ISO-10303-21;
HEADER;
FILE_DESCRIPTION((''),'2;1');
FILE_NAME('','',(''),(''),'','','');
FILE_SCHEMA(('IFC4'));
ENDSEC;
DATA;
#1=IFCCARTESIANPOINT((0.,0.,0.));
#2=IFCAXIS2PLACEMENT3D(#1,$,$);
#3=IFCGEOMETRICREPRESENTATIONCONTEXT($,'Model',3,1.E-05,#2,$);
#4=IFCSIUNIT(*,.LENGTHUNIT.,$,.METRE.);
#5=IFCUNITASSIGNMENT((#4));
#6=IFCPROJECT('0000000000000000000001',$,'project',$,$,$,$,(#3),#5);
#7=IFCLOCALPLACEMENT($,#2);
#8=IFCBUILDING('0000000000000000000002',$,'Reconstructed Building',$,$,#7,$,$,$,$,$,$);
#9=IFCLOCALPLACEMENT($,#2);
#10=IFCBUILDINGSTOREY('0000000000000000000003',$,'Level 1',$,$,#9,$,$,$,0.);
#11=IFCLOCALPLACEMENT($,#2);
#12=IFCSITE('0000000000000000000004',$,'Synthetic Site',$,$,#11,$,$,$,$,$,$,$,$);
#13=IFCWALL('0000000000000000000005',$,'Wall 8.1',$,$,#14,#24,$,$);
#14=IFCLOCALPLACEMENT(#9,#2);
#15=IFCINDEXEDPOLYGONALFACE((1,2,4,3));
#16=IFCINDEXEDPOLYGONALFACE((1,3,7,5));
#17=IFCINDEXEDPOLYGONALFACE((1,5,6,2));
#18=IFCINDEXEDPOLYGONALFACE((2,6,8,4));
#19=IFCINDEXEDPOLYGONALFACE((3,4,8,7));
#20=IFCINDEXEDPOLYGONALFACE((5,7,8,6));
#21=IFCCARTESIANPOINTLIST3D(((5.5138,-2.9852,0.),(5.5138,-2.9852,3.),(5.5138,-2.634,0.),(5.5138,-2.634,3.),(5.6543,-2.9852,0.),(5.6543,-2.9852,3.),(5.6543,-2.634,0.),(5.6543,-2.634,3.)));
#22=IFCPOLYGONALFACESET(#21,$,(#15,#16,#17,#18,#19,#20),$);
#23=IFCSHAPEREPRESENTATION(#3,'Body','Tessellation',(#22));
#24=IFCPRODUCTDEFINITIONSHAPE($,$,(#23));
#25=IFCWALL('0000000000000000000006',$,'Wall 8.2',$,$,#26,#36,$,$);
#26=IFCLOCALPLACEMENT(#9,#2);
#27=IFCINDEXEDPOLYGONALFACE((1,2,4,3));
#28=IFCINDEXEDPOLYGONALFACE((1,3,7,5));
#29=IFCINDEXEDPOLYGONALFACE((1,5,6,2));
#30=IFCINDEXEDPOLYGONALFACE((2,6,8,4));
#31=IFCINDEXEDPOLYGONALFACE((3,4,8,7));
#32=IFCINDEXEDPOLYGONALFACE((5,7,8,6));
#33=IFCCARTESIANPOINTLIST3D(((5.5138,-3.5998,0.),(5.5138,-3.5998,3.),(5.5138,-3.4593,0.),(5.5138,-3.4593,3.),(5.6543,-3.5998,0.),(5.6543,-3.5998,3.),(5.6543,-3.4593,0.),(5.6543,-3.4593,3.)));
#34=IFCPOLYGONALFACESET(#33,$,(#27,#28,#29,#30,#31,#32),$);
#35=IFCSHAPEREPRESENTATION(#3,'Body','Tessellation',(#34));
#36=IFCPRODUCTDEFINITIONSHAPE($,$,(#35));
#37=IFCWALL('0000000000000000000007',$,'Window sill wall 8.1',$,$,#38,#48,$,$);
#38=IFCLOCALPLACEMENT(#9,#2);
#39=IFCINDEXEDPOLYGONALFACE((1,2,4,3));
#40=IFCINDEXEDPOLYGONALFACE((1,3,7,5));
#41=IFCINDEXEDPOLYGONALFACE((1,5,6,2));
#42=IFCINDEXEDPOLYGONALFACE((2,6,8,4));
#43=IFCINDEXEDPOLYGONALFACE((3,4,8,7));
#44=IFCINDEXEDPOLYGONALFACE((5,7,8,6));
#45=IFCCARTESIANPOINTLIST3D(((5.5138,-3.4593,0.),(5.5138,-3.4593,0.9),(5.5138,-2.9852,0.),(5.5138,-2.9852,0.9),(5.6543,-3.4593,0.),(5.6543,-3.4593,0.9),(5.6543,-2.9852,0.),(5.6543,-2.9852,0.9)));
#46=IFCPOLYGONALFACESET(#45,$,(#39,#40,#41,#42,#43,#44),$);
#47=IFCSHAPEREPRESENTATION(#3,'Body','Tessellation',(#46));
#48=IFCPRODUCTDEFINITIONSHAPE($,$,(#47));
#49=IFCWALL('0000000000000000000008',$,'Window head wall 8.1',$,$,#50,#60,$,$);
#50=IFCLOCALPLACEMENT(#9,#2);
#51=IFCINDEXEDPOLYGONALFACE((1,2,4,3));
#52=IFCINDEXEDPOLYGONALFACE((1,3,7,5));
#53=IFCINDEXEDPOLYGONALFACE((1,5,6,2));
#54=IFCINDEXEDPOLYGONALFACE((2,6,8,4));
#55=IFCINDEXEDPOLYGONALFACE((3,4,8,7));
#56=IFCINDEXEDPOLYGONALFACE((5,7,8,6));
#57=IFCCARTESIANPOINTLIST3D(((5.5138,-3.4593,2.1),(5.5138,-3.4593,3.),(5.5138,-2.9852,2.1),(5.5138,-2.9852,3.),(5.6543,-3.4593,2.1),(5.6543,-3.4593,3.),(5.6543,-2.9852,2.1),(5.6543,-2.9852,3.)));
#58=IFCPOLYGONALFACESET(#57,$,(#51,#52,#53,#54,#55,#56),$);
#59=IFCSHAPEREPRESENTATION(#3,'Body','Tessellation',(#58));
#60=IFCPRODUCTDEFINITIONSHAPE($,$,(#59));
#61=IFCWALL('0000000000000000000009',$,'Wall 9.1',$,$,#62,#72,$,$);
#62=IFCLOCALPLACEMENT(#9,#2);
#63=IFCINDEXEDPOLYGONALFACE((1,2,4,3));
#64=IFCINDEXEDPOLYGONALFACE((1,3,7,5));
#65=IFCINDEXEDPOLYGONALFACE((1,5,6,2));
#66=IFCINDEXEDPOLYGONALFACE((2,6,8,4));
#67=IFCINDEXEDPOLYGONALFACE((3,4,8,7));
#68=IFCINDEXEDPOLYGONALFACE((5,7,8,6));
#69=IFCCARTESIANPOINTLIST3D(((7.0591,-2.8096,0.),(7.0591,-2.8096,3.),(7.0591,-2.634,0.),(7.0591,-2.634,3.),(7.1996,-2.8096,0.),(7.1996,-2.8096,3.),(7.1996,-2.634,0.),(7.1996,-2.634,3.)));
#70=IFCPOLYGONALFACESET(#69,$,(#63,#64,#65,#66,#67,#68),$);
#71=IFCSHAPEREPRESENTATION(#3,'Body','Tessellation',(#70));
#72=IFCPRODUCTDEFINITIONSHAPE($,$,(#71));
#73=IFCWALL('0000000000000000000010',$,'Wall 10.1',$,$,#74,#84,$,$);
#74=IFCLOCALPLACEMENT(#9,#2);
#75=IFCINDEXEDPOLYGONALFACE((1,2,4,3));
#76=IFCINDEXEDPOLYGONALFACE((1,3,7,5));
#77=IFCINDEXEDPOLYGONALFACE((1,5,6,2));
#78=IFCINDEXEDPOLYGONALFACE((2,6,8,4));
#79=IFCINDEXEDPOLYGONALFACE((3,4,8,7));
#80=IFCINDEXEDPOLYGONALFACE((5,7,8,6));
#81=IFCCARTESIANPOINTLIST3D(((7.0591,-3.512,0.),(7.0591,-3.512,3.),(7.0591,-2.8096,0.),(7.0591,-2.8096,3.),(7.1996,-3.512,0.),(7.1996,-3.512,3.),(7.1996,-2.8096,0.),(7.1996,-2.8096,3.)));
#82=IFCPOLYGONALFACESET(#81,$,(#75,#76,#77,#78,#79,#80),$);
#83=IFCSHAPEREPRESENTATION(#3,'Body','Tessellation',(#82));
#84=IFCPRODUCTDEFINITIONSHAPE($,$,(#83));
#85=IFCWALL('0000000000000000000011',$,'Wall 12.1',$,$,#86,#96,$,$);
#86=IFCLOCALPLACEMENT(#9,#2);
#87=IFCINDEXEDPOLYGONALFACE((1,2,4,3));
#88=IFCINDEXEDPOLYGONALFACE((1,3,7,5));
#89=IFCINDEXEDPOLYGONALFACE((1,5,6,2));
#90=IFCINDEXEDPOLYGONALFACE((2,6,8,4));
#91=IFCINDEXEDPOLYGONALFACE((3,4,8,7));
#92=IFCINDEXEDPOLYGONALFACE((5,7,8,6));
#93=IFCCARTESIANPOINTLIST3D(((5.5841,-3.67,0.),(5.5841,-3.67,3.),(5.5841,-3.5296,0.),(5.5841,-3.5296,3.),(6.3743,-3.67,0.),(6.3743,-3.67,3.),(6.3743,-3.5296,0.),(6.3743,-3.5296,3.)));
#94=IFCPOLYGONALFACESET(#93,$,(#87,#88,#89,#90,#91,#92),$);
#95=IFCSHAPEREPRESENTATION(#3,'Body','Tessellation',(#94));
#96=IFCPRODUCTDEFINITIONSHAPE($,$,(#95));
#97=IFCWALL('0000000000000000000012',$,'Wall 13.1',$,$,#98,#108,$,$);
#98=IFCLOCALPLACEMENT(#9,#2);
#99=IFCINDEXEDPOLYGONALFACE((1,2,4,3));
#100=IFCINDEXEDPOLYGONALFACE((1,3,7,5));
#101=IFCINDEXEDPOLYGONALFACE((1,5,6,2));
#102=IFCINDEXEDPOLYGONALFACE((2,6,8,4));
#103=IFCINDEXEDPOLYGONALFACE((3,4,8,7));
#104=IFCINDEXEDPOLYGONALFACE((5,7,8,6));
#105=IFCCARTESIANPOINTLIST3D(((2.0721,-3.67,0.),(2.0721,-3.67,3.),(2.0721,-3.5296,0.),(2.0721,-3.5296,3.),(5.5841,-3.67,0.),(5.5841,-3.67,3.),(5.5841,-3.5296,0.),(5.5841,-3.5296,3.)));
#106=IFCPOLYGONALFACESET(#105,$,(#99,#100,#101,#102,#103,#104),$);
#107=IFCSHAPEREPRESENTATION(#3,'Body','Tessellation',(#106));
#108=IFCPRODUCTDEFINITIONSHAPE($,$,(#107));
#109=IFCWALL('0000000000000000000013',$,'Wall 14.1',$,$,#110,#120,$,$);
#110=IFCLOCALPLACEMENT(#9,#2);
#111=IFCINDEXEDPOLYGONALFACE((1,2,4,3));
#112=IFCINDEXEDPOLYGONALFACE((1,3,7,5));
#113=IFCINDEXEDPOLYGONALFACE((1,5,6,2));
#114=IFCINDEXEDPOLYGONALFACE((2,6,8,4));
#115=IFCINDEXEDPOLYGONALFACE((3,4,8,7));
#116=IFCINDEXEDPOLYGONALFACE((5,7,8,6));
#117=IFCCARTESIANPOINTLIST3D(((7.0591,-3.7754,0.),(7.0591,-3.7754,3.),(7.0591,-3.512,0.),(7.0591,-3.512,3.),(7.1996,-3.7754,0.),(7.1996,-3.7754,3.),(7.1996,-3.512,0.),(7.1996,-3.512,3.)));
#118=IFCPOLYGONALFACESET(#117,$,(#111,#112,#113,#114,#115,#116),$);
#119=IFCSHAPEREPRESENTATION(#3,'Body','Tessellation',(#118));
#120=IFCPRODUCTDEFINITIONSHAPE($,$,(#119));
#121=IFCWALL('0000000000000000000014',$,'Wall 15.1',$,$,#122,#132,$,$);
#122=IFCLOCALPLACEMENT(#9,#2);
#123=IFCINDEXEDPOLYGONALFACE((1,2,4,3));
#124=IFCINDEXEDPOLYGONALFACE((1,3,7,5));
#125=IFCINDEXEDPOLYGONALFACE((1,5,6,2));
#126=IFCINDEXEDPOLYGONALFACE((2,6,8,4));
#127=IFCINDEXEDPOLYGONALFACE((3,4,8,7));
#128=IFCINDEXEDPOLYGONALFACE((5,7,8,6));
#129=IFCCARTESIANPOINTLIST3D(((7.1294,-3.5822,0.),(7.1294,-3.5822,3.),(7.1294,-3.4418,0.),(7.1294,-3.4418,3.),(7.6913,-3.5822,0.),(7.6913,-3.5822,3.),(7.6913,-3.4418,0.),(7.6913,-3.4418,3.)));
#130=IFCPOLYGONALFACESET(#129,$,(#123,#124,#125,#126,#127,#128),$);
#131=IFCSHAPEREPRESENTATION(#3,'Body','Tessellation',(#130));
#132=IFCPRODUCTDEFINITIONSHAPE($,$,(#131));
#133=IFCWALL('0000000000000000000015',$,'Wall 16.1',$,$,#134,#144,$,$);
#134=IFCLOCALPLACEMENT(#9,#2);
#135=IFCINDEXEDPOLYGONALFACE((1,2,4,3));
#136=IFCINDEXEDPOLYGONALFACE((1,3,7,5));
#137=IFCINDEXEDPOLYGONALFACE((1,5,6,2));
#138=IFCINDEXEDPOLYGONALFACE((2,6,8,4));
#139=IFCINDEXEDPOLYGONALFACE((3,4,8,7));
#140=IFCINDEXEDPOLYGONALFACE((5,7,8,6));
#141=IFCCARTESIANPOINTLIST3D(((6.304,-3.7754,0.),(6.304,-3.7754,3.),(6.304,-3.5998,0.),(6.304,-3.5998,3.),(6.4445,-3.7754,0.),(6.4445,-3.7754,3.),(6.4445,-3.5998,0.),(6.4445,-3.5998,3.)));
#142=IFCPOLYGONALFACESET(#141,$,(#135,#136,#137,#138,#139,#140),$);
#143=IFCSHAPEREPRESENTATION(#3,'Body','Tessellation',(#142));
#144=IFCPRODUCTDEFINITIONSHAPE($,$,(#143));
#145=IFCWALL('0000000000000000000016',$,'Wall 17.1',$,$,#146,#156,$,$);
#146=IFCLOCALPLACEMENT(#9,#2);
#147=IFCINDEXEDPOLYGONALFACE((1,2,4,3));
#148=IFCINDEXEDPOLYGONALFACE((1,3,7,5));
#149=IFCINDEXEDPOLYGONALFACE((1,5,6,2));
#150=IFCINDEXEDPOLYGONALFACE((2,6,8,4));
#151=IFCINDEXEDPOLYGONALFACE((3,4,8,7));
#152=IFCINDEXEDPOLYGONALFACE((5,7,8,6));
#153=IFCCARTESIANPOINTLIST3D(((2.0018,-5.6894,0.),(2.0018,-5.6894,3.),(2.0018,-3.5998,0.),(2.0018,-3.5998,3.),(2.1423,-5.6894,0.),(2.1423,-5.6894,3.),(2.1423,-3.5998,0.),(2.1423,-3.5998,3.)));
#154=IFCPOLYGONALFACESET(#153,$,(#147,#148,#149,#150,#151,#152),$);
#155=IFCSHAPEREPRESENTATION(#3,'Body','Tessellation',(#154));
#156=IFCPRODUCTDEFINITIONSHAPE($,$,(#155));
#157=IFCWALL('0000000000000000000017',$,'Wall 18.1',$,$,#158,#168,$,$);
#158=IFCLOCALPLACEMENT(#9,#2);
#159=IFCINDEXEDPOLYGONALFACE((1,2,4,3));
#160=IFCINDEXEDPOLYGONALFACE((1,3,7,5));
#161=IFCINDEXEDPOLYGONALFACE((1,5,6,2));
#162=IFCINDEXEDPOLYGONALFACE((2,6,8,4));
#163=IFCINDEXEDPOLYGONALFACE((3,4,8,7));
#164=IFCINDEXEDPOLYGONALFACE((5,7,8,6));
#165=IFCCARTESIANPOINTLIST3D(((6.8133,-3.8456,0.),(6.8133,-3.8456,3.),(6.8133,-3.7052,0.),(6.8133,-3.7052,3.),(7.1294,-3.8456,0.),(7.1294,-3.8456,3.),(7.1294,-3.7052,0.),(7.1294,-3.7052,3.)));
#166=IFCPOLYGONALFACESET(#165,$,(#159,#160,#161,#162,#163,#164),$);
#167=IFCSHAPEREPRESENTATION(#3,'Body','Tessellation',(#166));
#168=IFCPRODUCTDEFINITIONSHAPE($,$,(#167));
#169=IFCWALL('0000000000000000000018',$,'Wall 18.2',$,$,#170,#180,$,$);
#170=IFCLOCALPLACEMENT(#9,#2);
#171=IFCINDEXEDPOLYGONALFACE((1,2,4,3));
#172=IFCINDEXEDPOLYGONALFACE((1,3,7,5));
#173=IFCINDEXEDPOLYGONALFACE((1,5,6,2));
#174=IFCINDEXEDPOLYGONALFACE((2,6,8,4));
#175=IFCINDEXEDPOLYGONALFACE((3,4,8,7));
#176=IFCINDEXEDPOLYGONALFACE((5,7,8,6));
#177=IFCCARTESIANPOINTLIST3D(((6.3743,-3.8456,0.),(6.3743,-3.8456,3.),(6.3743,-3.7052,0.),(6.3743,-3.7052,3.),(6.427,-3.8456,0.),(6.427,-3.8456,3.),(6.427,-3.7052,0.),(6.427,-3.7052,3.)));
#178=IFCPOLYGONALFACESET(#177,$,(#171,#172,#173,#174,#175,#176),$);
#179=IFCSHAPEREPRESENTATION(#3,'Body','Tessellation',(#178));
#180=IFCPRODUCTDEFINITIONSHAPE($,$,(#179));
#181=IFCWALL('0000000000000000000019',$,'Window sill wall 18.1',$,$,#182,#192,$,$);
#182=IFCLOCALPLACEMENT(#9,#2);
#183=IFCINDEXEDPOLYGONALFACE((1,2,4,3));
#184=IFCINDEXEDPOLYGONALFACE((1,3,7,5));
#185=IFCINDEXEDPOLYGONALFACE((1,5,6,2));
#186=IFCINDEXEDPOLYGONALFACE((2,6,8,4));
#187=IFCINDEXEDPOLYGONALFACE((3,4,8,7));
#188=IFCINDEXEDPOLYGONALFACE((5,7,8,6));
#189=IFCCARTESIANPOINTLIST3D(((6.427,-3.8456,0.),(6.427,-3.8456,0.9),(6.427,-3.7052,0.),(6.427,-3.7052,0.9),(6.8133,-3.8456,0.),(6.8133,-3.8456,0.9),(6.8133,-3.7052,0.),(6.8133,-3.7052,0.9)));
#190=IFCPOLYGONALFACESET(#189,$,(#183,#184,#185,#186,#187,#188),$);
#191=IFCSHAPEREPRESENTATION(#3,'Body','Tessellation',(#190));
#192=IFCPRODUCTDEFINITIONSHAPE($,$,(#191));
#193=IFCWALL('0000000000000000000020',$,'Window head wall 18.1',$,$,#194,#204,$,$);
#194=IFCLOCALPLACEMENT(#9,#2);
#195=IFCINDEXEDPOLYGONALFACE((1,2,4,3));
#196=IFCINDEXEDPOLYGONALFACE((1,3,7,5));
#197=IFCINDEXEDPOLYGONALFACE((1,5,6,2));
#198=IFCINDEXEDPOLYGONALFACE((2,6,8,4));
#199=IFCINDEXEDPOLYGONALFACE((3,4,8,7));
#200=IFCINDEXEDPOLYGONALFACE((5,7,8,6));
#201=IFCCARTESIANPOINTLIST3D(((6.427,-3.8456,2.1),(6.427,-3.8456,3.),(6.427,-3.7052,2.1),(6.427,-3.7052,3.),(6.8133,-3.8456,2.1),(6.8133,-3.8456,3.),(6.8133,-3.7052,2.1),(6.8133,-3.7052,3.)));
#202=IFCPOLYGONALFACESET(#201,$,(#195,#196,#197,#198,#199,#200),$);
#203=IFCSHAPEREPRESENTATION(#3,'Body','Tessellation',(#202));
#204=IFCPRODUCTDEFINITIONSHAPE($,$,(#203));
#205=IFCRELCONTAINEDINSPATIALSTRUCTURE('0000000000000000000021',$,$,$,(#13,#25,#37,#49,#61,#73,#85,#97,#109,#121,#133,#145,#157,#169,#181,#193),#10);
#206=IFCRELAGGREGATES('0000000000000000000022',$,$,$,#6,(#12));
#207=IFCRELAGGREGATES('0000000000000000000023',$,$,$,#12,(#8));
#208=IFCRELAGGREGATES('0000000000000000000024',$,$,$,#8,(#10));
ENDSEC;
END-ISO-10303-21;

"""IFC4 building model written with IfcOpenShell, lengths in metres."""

from ifc_helpers import new_model, si_unit, frame, origin, place, context, project, spatial, polyline, outline, extrude, element, save


model = new_model("IFC4")

# Units and contexts
model_context = context("Model", 3, precision=1e-05, world=origin())
ifc_project = project(units=[si_unit("LENGTHUNIT", "METRE")], contexts=[model_context])

# Site, building, storey
site_placement = place(None, origin())
site = spatial("IfcSite", under=ifc_project, at=site_placement, Name="Synthetic Site")
building_placement = place(None, origin())
building = spatial("IfcBuilding", under=site, at=building_placement, Name="Reconstructed Building")
storey_placement = place(None, origin())
storey = spatial("IfcBuildingStorey", under=building, at=storey_placement, Name="Level 1", Elevation=0.0)

# Walls
wall_1_placement = place(None, origin())
element("IfcWall", 1, at=wall_1_placement, inside=storey, Name="Wall 8.1", context=model_context, shape_type="SweptSolid", body=[
    extrude(outline(polyline([(5.5138, -2.634), (5.5138, -2.9852), (5.6543, -2.9852), (5.6543, -2.634), (5.5138, -2.634)])), frame((0.0, 0.0, 0.0), z_axis=(0.0, 0.0, 1.0)), (0.0, 0.0, 1.0), 3.0),
])
wall_2_placement = place(None, origin())
element("IfcWall", 2, at=wall_2_placement, inside=storey, Name="Wall 8.2", context=model_context, shape_type="SweptSolid", body=[
    extrude(outline(polyline([(5.5138, -3.4593), (5.5138, -3.5998), (5.6543, -3.5998), (5.6543, -3.4593), (5.5138, -3.4593)])), frame((0.0, 0.0, 0.0), z_axis=(0.0, 0.0, 1.0)), (0.0, 0.0, 1.0), 3.0),
])
wall_3_placement = place(None, origin())
element("IfcWall", 3, at=wall_3_placement, inside=storey, Name="Window sill wall 8.1", context=model_context, shape_type="SweptSolid", body=[
    extrude(outline(polyline([(5.5138, -2.9852), (5.5138, -3.4593), (5.6543, -3.4593), (5.6543, -2.9852), (5.5138, -2.9852)])), frame((0.0, 0.0, 0.0), z_axis=(0.0, 0.0, 1.0)), (0.0, 0.0, 1.0), 0.9),
])
wall_4_placement = place(None, origin())
element("IfcWall", 4, at=wall_4_placement, inside=storey, Name="Window head wall 8.1", context=model_context, shape_type="SweptSolid", body=[
    extrude(outline(polyline([(5.5138, -2.9852), (5.5138, -3.4593), (5.6543, -3.4593), (5.6543, -2.9852), (5.5138, -2.9852)])), frame((0.0, 0.0, 2.1), z_axis=(0.0, 0.0, 1.0)), (0.0, 0.0, 1.0), 0.9),
])
wall_5_placement = place(None, origin())
element("IfcWall", 5, at=wall_5_placement, inside=storey, Name="Wall 9.1", context=model_context, shape_type="SweptSolid", body=[
    extrude(outline(polyline([(7.1996, -2.8096), (7.1996, -2.634), (7.0591, -2.634), (7.0591, -2.8096), (7.1996, -2.8096)])), frame((0.0, 0.0, 0.0), z_axis=(0.0, 0.0, 1.0)), (0.0, 0.0, 1.0), 3.0),
])
wall_6_placement = place(None, origin())
element("IfcWall", 6, at=wall_6_placement, inside=storey, Name="Wall 10.1", context=model_context, shape_type="SweptSolid", body=[
    extrude(outline(polyline([(7.0591, -2.8096), (7.0591, -3.512), (7.1996, -3.512), (7.1996, -2.8096), (7.0591, -2.8096)])), frame((0.0, 0.0, 0.0), z_axis=(0.0, 0.0, 1.0)), (0.0, 0.0, 1.0), 3.0),
])
wall_7_placement = place(None, origin())
element("IfcWall", 7, at=wall_7_placement, inside=storey, Name="Wall 12.1", context=model_context, shape_type="SweptSolid", body=[
    extrude(outline(polyline([(5.5841, -3.67), (6.3743, -3.67), (6.3743, -3.5296), (5.5841, -3.5296), (5.5841, -3.67)])), frame((0.0, 0.0, 0.0), z_axis=(0.0, 0.0, 1.0)), (0.0, 0.0, 1.0), 3.0),
])
wall_8_placement = place(None, origin())
element("IfcWall", 8, at=wall_8_placement, inside=storey, Name="Wall 13.1", context=model_context, shape_type="SweptSolid", body=[
    extrude(outline(polyline([(5.5841, -3.5296), (2.0721, -3.5296), (2.0721, -3.67), (5.5841, -3.67), (5.5841, -3.5296)])), frame((0.0, 0.0, 0.0), z_axis=(0.0, 0.0, 1.0)), (0.0, 0.0, 1.0), 3.0),
])
wall_9_placement = place(None, origin())
element("IfcWall", 9, at=wall_9_placement, inside=storey, Name="Wall 14.1", context=model_context, shape_type="SweptSolid", body=[
    extrude(outline(polyline([(7.0591, -3.512), (7.0591, -3.7754), (7.1996, -3.7754), (7.1996, -3.512), (7.0591, -3.512)])), frame((0.0, 0.0, 0.0), z_axis=(0.0, 0.0, 1.0)), (0.0, 0.0, 1.0), 3.0),
])
wall_10_placement = place(None, origin())
element("IfcWall", 10, at=wall_10_placement, inside=storey, Name="Wall 15.1", context=model_context, shape_type="SweptSolid", body=[
    extrude(outline(polyline([(7.1294, -3.5822), (7.6913, -3.5822), (7.6913, -3.4418), (7.1294, -3.4418), (7.1294, -3.5822)])), frame((0.0, 0.0, 0.0), z_axis=(0.0, 0.0, 1.0)), (0.0, 0.0, 1.0), 3.0),
])
wall_11_placement = place(None, origin())
element("IfcWall", 11, at=wall_11_placement, inside=storey, Name="Wall 16.1", context=model_context, shape_type="SweptSolid", body=[
    extrude(outline(polyline([(6.304, -3.5998), (6.304, -3.7754), (6.4445, -3.7754), (6.4445, -3.5998), (6.304, -3.5998)])), frame((0.0, 0.0, 0.0), z_axis=(0.0, 0.0, 1.0)), (0.0, 0.0, 1.0), 3.0),
])
wall_12_placement = place(None, origin())
element("IfcWall", 12, at=wall_12_placement, inside=storey, Name="Wall 17.1", context=model_context, shape_type="SweptSolid", body=[
    extrude(outline(polyline([(2.0018, -3.5998), (2.0018, -5.6894), (2.1423, -5.6894), (2.1423, -3.5998), (2.0018, -3.5998)])), frame((0.0, 0.0, 0.0), z_axis=(0.0, 0.0, 1.0)), (0.0, 0.0, 1.0), 3.0),
])
wall_13_placement = place(None, origin())
element("IfcWall", 13, at=wall_13_placement, inside=storey, Name="Wall 18.1", context=model_context, shape_type="SweptSolid", body=[
    extrude(outline(polyline([(7.1294, -3.7052), (6.8133, -3.7052), (6.8133, -3.8456), (7.1294, -3.8456), (7.1294, -3.7052)])), frame((0.0, 0.0, 0.0), z_axis=(0.0, 0.0, 1.0)), (0.0, 0.0, 1.0), 3.0),
])
wall_14_placement = place(None, origin())
element("IfcWall", 14, at=wall_14_placement, inside=storey, Name="Wall 18.2", context=model_context, shape_type="SweptSolid", body=[
    extrude(outline(polyline([(6.427, -3.7052), (6.3743, -3.7052), (6.3743, -3.8456), (6.427, -3.8456), (6.427, -3.7052)])), frame((0.0, 0.0, 0.0), z_axis=(0.0, 0.0, 1.0)), (0.0, 0.0, 1.0), 3.0),
])
wall_15_placement = place(None, origin())
element("IfcWall", 15, at=wall_15_placement, inside=storey, Name="Window sill wall 18.1", context=model_context, shape_type="SweptSolid", body=[
    extrude(outline(polyline([(6.8133, -3.7052), (6.427, -3.7052), (6.427, -3.8456), (6.8133, -3.8456), (6.8133, -3.7052)])), frame((0.0, 0.0, 0.0), z_axis=(0.0, 0.0, 1.0)), (0.0, 0.0, 1.0), 0.9),
])
wall_16_placement = place(None, origin())
element("IfcWall", 16, at=wall_16_placement, inside=storey, Name="Window head wall 18.1", context=model_context, shape_type="SweptSolid", body=[
    extrude(outline(polyline([(6.8133, -3.7052), (6.427, -3.7052), (6.427, -3.8456), (6.8133, -3.8456), (6.8133, -3.7052)])), frame((0.0, 0.0, 2.1), z_axis=(0.0, 0.0, 1.0)), (0.0, 0.0, 1.0), 0.9),
])

save(model, "model.ifc")
